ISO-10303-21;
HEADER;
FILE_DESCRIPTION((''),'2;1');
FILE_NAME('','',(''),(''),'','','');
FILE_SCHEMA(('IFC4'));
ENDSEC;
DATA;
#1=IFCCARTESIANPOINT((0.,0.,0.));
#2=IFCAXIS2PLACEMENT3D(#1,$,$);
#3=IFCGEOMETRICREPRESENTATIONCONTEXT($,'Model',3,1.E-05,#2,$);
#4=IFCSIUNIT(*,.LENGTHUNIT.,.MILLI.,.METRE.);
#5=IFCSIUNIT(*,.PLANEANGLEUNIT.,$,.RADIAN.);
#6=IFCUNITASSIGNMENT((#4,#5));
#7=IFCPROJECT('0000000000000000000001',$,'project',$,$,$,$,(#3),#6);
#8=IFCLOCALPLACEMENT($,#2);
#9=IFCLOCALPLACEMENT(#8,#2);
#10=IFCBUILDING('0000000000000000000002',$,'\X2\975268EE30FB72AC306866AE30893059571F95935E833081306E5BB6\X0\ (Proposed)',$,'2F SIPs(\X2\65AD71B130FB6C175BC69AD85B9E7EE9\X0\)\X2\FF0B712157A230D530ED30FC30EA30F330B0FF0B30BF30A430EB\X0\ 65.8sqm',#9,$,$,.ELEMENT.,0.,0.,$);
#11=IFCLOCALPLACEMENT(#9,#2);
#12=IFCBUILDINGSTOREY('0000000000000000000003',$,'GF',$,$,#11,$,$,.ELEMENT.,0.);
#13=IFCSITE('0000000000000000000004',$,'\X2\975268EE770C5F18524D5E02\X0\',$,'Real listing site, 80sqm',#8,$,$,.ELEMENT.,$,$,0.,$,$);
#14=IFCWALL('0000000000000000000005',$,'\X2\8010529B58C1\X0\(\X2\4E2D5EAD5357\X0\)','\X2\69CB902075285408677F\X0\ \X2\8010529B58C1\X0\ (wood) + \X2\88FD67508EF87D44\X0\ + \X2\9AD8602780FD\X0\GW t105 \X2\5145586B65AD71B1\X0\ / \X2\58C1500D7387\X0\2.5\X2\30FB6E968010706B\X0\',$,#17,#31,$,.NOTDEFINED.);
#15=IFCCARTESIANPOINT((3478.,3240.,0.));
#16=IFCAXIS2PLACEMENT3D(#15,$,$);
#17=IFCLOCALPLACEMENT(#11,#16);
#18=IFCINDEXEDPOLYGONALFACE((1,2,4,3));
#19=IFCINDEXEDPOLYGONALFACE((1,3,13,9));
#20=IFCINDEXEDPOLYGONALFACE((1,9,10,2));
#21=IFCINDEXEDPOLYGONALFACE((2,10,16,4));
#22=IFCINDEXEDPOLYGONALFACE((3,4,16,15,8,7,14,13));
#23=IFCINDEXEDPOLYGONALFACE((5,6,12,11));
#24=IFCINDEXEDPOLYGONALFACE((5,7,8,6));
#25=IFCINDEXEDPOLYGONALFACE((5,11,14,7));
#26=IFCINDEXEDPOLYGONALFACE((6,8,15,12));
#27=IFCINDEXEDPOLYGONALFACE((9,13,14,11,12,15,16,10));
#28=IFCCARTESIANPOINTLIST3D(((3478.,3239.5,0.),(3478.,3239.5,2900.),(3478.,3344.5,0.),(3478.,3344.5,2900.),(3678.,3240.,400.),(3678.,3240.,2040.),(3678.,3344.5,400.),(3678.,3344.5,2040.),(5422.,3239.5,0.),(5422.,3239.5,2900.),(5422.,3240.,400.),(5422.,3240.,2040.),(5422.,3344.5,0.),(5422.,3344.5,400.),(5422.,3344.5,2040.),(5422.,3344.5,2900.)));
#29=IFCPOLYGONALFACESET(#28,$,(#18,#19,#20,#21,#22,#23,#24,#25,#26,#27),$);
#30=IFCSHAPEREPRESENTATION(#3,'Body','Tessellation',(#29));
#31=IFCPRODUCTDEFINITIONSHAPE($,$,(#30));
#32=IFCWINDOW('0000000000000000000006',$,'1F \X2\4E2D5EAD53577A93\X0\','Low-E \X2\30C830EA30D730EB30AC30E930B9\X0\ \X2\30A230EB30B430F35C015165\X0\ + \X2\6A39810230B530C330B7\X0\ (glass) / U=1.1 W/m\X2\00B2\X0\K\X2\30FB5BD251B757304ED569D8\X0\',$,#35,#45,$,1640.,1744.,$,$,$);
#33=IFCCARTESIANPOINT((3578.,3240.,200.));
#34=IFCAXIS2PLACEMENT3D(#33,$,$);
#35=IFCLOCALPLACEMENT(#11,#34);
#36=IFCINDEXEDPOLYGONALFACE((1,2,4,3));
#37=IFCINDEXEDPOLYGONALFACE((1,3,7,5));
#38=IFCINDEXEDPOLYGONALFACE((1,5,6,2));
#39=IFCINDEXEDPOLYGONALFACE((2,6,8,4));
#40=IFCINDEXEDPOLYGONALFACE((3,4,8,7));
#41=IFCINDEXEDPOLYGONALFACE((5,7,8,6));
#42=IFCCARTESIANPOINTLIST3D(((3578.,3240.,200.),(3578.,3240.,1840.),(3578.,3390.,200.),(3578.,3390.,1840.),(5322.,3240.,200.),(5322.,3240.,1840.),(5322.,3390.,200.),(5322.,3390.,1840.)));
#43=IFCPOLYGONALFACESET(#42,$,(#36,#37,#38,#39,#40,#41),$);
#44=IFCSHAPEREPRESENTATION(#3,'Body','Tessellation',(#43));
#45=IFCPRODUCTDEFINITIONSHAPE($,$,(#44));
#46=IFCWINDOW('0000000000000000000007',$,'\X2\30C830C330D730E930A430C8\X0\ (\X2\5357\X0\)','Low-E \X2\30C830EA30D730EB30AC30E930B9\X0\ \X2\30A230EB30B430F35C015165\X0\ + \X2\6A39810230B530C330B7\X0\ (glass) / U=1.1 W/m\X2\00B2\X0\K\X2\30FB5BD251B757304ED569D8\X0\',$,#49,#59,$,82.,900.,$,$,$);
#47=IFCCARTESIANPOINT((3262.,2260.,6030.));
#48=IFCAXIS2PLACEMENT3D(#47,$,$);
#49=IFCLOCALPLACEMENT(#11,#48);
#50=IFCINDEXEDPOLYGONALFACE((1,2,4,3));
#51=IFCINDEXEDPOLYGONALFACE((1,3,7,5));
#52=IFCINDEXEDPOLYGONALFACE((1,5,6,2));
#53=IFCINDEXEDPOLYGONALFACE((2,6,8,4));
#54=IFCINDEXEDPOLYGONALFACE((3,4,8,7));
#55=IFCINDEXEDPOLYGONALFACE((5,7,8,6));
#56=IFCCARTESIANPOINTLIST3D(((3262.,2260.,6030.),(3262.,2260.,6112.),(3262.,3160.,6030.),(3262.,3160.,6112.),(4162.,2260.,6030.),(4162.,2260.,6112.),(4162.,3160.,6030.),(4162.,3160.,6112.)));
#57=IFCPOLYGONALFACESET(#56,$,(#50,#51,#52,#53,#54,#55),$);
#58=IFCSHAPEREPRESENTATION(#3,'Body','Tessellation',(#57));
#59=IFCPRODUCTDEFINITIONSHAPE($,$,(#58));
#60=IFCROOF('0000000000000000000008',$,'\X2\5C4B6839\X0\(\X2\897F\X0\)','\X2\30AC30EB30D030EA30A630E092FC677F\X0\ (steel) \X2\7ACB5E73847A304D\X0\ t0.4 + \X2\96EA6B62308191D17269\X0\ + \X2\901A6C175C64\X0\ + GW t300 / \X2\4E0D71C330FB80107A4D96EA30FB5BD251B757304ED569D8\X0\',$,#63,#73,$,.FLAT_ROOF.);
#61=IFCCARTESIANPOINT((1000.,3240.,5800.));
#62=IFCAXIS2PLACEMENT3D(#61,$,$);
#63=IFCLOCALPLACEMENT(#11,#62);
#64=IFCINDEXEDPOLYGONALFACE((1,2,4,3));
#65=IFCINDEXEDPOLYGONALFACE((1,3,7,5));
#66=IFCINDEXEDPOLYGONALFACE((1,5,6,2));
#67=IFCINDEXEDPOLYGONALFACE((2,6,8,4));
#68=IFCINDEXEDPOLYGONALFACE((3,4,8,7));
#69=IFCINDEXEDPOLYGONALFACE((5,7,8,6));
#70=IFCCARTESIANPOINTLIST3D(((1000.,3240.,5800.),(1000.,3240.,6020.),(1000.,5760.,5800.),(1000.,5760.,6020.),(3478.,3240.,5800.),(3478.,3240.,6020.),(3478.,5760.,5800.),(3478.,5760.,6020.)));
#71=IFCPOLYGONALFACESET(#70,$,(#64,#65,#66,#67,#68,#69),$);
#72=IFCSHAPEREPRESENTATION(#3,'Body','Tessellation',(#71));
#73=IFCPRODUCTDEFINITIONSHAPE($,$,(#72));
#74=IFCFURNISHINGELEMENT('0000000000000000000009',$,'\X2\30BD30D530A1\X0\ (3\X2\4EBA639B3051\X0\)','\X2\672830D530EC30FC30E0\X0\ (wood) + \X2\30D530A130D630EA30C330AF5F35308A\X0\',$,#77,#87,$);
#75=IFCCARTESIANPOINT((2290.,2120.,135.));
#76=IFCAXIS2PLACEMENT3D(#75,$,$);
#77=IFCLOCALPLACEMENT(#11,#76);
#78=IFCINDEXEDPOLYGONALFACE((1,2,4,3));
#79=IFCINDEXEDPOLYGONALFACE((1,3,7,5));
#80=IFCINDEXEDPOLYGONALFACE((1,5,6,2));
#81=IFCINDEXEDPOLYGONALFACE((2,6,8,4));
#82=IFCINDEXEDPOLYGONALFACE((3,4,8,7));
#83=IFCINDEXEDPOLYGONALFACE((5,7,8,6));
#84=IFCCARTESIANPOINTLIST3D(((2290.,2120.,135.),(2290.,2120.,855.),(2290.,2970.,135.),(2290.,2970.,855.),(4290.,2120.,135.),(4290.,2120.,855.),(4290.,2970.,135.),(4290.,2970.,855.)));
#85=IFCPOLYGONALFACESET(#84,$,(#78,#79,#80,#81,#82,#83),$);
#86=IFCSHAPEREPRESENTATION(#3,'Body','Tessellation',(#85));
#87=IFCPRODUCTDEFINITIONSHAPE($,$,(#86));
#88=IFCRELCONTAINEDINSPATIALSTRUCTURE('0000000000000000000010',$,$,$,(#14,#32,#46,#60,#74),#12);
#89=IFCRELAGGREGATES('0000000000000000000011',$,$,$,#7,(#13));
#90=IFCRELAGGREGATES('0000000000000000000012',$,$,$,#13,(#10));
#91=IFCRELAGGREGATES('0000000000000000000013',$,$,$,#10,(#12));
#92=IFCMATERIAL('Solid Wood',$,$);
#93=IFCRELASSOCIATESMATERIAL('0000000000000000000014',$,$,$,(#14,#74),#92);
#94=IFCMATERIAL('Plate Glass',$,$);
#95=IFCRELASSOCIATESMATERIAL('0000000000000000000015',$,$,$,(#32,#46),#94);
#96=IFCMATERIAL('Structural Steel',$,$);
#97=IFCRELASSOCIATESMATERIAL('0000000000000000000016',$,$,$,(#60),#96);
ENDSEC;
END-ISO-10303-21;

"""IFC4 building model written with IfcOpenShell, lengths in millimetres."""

from ifc_helpers import new_model, si_unit, frame, frame_2d, origin, place, context, project, spatial, rectangle, extrude, material, element, fill, save


model = new_model("IFC4")

# Units and contexts
model_context = context("Model", 3, precision=1e-05, world=origin())
ifc_project = project(units=[si_unit("LENGTHUNIT", "METRE", prefix="MILLI"), si_unit("PLANEANGLEUNIT", "RADIAN")], contexts=[model_context])

# Site, building, storey
site_placement = place(None, origin())
site = spatial("IfcSite", under=ifc_project, at=site_placement, Name="青森県弘前市", ObjectType="Real listing site, 80sqm", CompositionType="ELEMENT", RefElevation=0.0)
building_placement = place(site_placement, origin())
building = spatial("IfcBuilding", under=site, at=building_placement, Name="青森・犬と暮らす土間広めの家 (Proposed)", ObjectType="2F SIPs(断熱・気密高实绩)＋無垢フローリング＋タイル 65.8sqm", CompositionType="ELEMENT", ElevationOfRefHeight=0.0, ElevationOfTerrain=0.0)
storey_placement = place(building_placement, origin())
storey = spatial("IfcBuildingStorey", under=building, at=storey_placement, Name="GF", CompositionType="ELEMENT", Elevation=0.0)

# Shared definitions
ifc_material_1 = material(Name="Solid Wood")

# Wall, opening, window
wall_1_placement = place(storey_placement, frame((3478.0, 3240.0, 0.0)))
wall_1 = element("IfcWall", 1, at=wall_1_placement, inside=storey, material=ifc_material_1, Name="耐力壁(中庭南)", Description="構造用合板 耐力壁 (wood) + 製材軸組 + 高性能GW t105 充填断熱 / 壁倍率2.5・準耐火", PredefinedType="NOTDEFINED", context=model_context, shape_type="SweptSolid", body=[
    extrude(rectangle(XDim=1944.0, YDim=105.0, at=frame_2d((972.0, 52.0))), frame((3478.0, 3240.0, 0.0)), (0.0, 0.0, 1.0), 2900.0),
])
opening_placement = place(storey_placement, frame((3578.0, 3240.0, 200.0)))
opening = element("IfcOpeningElement", 2, at=opening_placement, cuts=wall_1, PredefinedType="NOTDEFINED", context=model_context, shape_type="SweptSolid", body=[
    extrude(rectangle(XDim=1744.0, YDim=150.0, at=frame_2d((872.0, 75.0))), frame((3578.0, 3240.0, 200.0)), (0.0, 0.0, 1.0), 1640.0),
])
ifc_material_2 = material(Name="Plate Glass")
window_1_placement = place(storey_placement, frame((3578.0, 3240.0, 200.0)))
window_1 = element("IfcWindow", 3, at=window_1_placement, inside=storey, material=ifc_material_2, Name="1F 中庭南窓", Description="Low-E トリプルガラス アルゴン封入 + 樹脂サッシ (glass) / U=1.1 W/m²K・寒冷地仕様", OverallHeight=1640.0, OverallWidth=1744.0, context=model_context, shape_type="SweptSolid", body=[
    extrude(rectangle(XDim=1744.0, YDim=150.0, at=frame_2d((872.0, 75.0))), frame((3578.0, 3240.0, 200.0)), (0.0, 0.0, 1.0), 1640.0),
])
fill(opening, window_1)

# Window
window_2_placement = place(storey_placement, frame((3262.0, 2260.0, 6030.0)))
element("IfcWindow", 4, at=window_2_placement, inside=storey, material=ifc_material_2, Name="トップライト (南)", Description="Low-E トリプルガラス アルゴン封入 + 樹脂サッシ (glass) / U=1.1 W/m²K・寒冷地仕様", OverallHeight=82.0, OverallWidth=900.0, context=model_context, shape_type="SweptSolid", body=[
    extrude(rectangle(XDim=900.0, YDim=900.0, at=frame_2d((450.0, 450.0))), frame((3262.0, 2260.0, 6030.0)), (0.0, 0.0, 1.0), 82.0),
])

# Roof
ifc_material_3 = material(Name="Structural Steel")
for number, where, name in (
    (5, (1000.0, 3240.0, 5800.0), "屋根(西)"),
):
    element("IfcRoof", number, at=place(storey_placement, frame(where)), inside=storey, material=ifc_material_3, Name=name, Description="ガルバリウム鋼板 (steel) 立平葺き t0.4 + 雪止め金物 + 通気層 + GW t300 / 不燃・耐積雪・寒冷地仕様", PredefinedType="FLAT_ROOF", context=model_context, shape_type="SweptSolid", body=[
        extrude(rectangle(XDim=2478.0, YDim=2520.0, at=frame_2d((1239.0, 1260.0))), frame((1000.0, 3240.0, 5800.0)), (0.0, 0.0, 1.0), 220.0),
    ])

# Furnishing element
furnishing_placement = place(storey_placement, frame((2290.0, 2120.0, 135.0)))
element("IfcFurnishingElement", 6, at=furnishing_placement, inside=storey, material=ifc_material_1, Name="ソファ (3人掛け)", Description="木フレーム (wood) + ファブリック張り", context=model_context, shape_type="SweptSolid", body=[
    extrude(rectangle(XDim=2000.0, YDim=850.0, at=frame_2d((1000.0, 425.0))), frame((2290.0, 2120.0, 135.0)), (0.0, 0.0, 1.0), 720.0),
])

save(model, "model.ifc")
